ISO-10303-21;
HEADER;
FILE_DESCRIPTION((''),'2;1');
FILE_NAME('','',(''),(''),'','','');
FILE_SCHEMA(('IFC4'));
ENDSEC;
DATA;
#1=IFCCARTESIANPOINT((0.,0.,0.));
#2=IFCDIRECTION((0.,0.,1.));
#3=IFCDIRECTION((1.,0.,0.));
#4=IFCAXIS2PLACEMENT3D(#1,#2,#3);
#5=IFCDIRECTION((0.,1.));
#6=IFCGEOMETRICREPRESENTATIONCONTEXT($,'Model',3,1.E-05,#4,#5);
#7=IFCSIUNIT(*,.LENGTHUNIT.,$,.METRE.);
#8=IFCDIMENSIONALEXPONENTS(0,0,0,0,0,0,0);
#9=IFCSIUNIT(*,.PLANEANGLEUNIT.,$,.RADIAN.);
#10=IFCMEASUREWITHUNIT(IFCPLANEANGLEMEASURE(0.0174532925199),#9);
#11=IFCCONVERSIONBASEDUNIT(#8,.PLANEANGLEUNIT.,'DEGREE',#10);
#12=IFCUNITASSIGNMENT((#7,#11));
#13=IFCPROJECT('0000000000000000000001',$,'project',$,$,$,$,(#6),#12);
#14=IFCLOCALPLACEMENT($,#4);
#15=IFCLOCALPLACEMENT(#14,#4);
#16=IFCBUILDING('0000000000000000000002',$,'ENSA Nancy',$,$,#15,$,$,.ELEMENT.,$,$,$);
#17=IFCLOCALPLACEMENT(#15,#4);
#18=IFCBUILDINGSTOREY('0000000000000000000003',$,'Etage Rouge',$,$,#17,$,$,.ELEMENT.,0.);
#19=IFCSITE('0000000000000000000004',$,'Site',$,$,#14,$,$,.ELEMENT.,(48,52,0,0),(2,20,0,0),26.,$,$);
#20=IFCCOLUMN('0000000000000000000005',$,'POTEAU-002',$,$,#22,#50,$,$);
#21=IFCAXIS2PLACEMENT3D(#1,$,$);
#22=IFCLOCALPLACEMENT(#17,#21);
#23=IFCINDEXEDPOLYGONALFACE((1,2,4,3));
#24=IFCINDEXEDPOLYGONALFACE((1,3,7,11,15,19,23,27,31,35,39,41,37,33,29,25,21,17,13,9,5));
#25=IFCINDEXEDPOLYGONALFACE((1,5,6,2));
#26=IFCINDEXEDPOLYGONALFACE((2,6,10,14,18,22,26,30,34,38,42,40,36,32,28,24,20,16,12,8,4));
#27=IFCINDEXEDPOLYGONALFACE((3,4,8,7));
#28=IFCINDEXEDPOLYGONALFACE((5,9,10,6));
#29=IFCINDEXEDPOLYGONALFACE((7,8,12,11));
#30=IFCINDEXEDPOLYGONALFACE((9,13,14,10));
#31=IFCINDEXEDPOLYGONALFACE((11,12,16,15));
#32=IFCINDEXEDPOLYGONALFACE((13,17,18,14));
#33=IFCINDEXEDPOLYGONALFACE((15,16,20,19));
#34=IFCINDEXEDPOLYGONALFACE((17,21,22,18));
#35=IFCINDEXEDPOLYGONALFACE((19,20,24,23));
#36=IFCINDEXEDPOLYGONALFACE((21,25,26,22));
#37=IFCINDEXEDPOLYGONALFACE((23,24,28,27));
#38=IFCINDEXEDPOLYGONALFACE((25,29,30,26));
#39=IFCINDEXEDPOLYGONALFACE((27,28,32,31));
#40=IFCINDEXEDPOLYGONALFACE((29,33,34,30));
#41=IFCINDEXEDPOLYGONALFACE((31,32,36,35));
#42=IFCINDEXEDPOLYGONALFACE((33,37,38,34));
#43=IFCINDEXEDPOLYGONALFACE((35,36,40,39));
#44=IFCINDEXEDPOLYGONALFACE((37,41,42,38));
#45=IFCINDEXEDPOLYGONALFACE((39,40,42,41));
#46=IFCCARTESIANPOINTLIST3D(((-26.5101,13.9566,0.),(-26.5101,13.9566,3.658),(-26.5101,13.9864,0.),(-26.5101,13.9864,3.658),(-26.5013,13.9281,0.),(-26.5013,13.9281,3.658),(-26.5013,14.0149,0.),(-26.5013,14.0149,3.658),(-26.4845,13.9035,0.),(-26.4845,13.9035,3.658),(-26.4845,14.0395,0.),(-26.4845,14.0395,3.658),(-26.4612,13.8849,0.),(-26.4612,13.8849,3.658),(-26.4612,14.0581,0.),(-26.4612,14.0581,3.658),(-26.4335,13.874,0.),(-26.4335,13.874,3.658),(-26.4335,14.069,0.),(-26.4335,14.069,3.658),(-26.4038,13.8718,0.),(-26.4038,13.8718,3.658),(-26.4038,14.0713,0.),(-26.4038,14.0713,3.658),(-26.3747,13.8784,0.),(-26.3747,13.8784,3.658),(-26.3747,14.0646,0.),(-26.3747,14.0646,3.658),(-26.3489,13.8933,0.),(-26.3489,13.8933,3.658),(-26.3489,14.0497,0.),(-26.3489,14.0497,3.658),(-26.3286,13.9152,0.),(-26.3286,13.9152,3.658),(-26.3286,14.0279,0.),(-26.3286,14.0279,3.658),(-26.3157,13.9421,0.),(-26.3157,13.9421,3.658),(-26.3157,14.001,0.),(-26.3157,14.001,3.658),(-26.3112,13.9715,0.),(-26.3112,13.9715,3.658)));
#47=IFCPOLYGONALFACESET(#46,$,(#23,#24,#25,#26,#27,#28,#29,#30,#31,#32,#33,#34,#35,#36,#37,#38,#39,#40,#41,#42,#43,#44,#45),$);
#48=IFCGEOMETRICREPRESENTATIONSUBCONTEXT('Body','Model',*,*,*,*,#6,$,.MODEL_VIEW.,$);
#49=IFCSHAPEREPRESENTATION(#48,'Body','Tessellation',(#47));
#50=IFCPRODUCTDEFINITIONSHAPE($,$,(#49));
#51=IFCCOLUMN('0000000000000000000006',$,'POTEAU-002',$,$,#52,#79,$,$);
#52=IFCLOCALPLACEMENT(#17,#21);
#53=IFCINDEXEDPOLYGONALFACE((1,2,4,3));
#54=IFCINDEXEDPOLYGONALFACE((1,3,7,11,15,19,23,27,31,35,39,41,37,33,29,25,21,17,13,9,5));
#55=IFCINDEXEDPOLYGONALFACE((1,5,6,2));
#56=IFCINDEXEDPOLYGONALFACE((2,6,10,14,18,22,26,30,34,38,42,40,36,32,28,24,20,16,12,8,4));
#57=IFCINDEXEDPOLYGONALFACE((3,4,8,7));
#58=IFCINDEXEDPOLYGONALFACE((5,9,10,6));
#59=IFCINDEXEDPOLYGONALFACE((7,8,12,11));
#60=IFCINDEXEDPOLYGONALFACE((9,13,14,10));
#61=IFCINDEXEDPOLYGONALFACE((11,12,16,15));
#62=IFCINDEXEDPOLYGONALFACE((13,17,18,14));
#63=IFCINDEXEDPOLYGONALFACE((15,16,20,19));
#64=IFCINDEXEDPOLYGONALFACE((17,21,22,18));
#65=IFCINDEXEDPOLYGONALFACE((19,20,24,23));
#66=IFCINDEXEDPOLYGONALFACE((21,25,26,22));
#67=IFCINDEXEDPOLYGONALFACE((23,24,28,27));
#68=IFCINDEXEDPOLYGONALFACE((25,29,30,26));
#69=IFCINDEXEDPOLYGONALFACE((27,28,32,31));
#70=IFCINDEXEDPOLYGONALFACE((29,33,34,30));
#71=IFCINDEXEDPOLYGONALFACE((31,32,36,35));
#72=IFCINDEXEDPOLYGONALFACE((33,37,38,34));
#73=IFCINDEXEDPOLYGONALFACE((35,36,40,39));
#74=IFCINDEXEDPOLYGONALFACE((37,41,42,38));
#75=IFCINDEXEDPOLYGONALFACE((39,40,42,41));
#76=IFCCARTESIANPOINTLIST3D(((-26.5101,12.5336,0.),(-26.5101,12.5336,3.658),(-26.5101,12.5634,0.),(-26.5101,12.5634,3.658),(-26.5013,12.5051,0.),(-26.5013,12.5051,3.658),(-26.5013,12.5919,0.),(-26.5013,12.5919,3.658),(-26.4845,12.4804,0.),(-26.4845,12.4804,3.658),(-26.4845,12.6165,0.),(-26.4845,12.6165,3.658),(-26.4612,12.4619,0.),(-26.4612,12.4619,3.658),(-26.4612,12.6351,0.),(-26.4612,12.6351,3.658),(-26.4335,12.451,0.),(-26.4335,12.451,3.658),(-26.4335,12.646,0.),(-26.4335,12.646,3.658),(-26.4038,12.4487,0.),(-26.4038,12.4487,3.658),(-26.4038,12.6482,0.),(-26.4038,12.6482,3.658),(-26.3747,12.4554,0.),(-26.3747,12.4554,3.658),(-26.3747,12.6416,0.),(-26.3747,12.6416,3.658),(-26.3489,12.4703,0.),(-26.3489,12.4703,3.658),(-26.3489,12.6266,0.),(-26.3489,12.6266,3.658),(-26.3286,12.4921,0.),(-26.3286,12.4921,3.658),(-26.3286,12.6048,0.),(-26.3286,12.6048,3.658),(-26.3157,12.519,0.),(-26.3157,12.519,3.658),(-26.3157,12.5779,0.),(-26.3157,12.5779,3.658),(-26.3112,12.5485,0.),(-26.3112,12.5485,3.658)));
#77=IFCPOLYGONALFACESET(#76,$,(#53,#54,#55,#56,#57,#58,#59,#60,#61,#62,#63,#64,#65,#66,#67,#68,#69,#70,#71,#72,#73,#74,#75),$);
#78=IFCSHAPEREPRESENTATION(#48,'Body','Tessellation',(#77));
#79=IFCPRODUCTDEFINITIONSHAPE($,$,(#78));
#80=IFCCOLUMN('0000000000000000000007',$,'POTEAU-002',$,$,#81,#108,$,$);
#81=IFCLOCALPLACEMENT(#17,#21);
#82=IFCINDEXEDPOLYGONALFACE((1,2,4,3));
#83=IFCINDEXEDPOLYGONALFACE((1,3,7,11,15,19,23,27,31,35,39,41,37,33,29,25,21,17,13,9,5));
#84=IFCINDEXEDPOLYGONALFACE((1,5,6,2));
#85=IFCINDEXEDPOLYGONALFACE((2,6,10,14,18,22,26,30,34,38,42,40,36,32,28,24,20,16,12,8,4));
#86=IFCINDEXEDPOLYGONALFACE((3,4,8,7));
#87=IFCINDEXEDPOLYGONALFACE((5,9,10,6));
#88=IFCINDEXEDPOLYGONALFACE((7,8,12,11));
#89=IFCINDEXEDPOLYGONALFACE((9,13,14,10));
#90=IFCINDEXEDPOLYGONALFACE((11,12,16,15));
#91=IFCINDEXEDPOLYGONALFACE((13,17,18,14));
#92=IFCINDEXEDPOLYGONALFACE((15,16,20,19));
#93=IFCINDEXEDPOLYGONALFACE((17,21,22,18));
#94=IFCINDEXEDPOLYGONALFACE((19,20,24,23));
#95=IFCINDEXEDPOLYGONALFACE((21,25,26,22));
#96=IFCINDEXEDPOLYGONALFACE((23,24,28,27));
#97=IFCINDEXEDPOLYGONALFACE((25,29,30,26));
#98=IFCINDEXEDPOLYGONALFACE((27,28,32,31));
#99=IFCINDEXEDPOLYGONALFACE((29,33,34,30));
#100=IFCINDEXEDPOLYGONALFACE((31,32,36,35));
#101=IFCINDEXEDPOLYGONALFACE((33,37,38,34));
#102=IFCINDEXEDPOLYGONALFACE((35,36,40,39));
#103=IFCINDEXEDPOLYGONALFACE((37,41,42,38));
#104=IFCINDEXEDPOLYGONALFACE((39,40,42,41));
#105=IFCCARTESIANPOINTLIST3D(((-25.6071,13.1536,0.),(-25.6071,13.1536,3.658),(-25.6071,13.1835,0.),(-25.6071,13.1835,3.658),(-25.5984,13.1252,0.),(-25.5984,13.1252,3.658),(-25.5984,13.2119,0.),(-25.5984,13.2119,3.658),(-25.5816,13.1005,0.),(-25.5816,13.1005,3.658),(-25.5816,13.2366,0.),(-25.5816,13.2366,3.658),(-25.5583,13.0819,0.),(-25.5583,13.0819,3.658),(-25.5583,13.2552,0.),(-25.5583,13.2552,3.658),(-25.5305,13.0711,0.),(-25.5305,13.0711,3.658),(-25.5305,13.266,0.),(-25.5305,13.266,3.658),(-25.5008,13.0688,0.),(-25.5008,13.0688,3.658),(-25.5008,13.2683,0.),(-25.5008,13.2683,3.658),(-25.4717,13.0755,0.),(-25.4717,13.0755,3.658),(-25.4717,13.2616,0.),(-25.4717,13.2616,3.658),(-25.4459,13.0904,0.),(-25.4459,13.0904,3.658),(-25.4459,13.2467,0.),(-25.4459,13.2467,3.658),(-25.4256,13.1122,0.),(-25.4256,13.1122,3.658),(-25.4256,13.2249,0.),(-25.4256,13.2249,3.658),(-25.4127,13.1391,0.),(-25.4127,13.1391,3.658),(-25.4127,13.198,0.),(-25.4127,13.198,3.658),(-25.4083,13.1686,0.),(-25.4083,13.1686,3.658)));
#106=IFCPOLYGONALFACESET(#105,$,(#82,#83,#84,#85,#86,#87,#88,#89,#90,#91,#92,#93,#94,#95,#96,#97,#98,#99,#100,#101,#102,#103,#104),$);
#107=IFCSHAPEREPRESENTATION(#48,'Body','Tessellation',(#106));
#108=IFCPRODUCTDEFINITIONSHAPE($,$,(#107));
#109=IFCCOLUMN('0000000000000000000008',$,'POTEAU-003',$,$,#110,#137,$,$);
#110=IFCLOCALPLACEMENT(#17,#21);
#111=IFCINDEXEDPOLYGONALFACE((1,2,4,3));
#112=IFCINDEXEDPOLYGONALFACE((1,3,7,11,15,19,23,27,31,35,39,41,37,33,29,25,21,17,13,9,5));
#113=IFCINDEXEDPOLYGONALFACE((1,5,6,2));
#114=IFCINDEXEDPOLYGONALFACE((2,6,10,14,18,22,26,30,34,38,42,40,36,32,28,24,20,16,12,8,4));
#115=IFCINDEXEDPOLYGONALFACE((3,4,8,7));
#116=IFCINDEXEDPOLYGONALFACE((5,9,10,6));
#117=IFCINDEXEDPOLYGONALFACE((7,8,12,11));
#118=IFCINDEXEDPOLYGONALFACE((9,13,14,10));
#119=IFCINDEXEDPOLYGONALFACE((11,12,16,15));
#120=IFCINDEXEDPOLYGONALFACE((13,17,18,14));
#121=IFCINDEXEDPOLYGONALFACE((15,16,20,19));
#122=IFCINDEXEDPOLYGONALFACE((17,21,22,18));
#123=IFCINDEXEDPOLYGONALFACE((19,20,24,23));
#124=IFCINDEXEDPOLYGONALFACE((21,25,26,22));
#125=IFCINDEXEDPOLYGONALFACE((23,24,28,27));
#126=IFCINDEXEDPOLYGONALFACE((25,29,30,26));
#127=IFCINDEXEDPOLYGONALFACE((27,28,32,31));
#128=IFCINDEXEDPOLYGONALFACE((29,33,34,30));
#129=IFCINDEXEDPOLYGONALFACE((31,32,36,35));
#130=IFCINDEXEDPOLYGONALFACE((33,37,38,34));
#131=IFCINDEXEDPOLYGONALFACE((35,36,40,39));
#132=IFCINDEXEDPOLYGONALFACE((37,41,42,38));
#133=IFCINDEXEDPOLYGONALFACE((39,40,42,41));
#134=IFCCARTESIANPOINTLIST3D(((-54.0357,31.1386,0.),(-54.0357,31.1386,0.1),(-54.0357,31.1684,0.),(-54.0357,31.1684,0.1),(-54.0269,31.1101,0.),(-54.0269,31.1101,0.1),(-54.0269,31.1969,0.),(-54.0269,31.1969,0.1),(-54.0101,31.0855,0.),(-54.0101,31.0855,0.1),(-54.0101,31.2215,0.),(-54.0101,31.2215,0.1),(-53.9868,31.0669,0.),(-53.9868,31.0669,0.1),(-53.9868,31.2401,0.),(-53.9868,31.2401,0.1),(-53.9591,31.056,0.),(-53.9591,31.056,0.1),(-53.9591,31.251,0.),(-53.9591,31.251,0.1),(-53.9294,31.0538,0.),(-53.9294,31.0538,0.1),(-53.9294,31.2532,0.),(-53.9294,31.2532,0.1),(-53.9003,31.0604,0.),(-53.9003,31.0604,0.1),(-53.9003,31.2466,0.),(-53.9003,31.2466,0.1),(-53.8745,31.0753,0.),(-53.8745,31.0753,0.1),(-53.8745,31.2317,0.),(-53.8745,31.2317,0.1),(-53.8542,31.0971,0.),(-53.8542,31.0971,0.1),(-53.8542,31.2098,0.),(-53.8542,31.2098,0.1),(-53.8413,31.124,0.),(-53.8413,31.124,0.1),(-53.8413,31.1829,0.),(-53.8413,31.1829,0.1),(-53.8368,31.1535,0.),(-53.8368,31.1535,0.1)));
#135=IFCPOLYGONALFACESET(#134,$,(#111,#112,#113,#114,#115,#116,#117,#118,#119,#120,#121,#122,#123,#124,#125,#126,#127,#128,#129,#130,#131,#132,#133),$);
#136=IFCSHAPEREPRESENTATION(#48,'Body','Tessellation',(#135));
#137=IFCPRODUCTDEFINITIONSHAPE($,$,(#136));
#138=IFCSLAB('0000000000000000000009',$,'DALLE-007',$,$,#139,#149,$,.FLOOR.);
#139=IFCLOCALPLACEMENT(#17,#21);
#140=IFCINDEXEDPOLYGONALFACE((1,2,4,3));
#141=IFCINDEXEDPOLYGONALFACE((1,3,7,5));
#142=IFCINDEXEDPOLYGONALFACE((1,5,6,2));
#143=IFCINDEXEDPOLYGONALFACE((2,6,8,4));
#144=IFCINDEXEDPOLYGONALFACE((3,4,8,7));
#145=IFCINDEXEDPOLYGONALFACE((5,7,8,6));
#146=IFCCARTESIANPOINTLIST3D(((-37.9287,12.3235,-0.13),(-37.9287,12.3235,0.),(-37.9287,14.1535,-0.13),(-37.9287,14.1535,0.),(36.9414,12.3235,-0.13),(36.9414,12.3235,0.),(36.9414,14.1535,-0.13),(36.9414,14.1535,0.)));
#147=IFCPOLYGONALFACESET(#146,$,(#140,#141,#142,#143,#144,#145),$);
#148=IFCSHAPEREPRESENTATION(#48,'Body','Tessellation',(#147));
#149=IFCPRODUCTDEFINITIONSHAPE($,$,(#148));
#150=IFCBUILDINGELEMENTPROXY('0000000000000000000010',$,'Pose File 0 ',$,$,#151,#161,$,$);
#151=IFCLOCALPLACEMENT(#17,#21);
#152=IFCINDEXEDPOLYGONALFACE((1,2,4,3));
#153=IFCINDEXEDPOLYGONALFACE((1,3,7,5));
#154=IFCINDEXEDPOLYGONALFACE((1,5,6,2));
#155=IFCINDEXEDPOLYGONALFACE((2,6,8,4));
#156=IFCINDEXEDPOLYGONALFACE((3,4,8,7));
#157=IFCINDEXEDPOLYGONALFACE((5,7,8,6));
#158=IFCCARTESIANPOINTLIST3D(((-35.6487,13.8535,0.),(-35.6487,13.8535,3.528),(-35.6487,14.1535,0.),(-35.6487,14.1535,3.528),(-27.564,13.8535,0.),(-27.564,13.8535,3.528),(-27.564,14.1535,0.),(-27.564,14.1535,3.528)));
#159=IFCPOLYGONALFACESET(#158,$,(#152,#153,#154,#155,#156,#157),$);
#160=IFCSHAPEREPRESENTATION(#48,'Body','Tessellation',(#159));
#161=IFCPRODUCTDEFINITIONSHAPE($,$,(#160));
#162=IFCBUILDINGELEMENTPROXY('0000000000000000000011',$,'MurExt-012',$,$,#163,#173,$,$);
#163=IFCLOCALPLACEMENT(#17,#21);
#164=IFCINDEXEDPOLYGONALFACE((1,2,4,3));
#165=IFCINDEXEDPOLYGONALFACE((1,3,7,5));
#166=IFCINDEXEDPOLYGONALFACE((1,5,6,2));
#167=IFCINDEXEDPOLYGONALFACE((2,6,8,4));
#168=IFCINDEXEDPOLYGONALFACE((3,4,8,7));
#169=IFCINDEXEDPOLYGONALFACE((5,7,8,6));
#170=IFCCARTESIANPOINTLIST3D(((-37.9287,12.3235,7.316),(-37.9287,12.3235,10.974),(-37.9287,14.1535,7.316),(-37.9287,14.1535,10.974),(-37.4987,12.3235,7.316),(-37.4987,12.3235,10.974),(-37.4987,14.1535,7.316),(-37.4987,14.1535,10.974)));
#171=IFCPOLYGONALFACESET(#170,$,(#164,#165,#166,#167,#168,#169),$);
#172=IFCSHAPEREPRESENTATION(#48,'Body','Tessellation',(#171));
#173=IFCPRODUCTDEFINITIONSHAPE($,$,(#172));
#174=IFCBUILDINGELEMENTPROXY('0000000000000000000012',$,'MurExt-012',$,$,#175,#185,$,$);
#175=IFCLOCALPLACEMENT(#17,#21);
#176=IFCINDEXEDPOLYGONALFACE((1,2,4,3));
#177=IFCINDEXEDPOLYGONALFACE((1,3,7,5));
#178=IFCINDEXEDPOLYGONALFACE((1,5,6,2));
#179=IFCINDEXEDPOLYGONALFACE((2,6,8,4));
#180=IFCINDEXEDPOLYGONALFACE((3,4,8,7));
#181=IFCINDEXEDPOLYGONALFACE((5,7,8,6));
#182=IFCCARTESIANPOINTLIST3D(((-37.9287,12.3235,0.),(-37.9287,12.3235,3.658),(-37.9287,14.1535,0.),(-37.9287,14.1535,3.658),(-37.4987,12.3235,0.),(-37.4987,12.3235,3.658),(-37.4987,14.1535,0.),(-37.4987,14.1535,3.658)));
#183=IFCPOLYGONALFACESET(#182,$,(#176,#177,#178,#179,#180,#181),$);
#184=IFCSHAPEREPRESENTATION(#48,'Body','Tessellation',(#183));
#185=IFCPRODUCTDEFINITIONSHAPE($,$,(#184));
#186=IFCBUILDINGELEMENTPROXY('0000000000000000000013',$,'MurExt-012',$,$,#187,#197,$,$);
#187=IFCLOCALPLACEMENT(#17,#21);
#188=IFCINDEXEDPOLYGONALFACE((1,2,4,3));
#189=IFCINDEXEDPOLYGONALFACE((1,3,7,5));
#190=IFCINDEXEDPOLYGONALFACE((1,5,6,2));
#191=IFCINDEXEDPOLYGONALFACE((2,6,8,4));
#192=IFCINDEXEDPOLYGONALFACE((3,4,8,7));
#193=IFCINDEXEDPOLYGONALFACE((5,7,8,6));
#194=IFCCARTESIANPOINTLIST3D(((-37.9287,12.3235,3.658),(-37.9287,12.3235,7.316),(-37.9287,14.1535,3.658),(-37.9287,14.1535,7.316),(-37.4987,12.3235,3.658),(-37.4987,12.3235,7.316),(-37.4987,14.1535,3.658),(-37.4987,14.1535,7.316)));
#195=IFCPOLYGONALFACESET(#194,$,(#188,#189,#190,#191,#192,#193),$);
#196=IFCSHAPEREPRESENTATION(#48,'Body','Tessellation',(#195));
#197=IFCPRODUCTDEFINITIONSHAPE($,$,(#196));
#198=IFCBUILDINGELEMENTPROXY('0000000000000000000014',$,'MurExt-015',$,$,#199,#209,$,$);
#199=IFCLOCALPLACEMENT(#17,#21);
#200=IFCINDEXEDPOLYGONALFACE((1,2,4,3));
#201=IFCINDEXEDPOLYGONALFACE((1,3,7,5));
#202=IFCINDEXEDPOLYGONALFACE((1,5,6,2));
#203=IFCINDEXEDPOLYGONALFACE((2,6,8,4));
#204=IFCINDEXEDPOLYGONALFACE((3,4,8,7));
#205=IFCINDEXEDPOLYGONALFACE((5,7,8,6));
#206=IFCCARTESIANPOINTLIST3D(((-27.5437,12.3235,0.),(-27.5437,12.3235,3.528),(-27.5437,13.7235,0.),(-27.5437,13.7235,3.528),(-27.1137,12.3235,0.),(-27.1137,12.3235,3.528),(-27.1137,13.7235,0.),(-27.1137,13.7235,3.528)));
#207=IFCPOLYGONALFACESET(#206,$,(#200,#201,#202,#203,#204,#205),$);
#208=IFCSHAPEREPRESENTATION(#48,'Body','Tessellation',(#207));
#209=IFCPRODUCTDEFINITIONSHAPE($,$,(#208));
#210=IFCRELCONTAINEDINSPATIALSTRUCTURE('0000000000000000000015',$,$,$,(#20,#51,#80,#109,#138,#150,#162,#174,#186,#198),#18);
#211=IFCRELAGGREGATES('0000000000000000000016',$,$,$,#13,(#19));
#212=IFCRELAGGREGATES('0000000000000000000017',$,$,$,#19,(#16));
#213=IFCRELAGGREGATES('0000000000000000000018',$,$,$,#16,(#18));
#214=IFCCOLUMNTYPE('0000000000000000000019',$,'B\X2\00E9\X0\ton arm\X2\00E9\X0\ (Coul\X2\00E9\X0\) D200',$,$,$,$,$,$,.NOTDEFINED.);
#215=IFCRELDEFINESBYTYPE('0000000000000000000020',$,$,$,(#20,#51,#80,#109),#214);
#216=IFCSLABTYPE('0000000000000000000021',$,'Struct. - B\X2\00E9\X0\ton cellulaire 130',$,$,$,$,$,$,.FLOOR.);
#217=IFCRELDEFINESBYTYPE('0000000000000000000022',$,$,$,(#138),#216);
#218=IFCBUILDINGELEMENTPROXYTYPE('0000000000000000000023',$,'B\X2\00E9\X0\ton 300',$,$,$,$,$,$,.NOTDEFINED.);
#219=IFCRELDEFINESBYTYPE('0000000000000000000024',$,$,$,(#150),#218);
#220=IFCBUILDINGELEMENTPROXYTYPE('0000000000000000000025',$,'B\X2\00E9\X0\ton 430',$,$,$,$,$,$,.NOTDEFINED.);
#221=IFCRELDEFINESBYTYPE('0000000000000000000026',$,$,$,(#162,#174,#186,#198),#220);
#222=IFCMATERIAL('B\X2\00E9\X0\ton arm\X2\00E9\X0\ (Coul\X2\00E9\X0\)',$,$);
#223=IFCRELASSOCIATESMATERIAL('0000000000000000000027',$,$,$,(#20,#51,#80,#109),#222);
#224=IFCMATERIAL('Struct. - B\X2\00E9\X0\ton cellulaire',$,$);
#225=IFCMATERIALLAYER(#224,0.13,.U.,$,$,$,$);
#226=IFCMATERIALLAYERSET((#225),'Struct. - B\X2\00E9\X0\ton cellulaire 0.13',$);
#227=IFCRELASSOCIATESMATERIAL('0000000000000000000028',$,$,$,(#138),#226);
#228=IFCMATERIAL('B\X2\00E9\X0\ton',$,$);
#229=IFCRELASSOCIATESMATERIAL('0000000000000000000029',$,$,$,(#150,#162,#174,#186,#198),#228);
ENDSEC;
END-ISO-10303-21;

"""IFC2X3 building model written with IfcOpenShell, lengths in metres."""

from ifc_helpers import new_model, entity, si_unit, converted_unit, direction, frame, origin_with_axes, origin_2d_with_axis, place, context, subcontext, project, spatial, polyline, circle, outline, extrude, material, layer, layer_set, layer_usage, type_object, element, save


model = new_model("IFC2X3")

# Units and contexts
model_context = context("Model", 3, precision=1e-05, world=origin_with_axes(), true_north=direction((0.0, 1.0)))
body_context = subcontext(model_context, "Body", "Model", "MODEL_VIEW")
ifc_project = project(units=[si_unit("LENGTHUNIT", "METRE"), converted_unit("PLANEANGLEUNIT", "DEGREE", entity("IfcPlaneAngleMeasure", 0.0174532925199), si_unit("PLANEANGLEUNIT", "RADIAN"), dimensions=[0, 0, 0, 0, 0, 0, 0])], contexts=[model_context])

# Site, building, storey
site_placement = place(None, origin_with_axes())
site = spatial("IfcSite", under=ifc_project, at=site_placement, Name="Site", CompositionType="ELEMENT", RefLatitude=(48, 52, 0, 0), RefLongitude=(2, 20, 0, 0), RefElevation=26.0)
building_placement = place(site_placement, origin_with_axes())
building = spatial("IfcBuilding", under=site, at=building_placement, Name="ENSA Nancy", CompositionType="ELEMENT")
storey_placement = place(building_placement, origin_with_axes())
storey = spatial("IfcBuildingStorey", under=building, at=storey_placement, Name="Etage Rouge", CompositionType="ELEMENT", Elevation=0.0)

# Columns
ifc_material_1 = material(Name="Béton armé (Coulé)")
column_type = type_object("IfcColumnType", Name="Béton armé (Coulé) D200", PredefinedType="NOTDEFINED")
for number, where, z_axis, x_axis, name in (
    (1, (-26.4112, 13.9715, 0.0), (0.0, 0.0, 1.0), (1.0, 0.0, 0.0), "POTEAU-002"),
    (2, (-26.4112, 12.5485, 0.0), (0.0, 0.0, 1.0), (1.0, 0.0, 0.0), "POTEAU-002"),
    (3, (-25.5083, 13.1686, 0.0), (0.0, 0.0, 1.0), (1.0, 0.0, 0.0), "POTEAU-002"),
):
    element("IfcColumn", number, at=place(storey_placement, frame(where, z_axis=z_axis, x_axis=x_axis)), inside=storey, type_object=column_type, material=ifc_material_1, Name=name, context=body_context, shape_type="SweptSolid", body=[
        extrude(circle(Radius=0.1, at=origin_2d_with_axis()), origin_with_axes(), (0.0, 0.0, 1.0), 3.658),
    ])
column_placement = place(storey_placement, frame((-53.9368, 31.1535, 0.0), z_axis=(0.0, 0.0, 1.0), x_axis=(1.0, 0.0, 0.0)))
element("IfcColumn", 4, at=column_placement, inside=storey, type_object=column_type, material=ifc_material_1, Name="POTEAU-003", context=body_context, shape_type="SweptSolid", body=[
    extrude(circle(Radius=0.1, at=origin_2d_with_axis()), origin_with_axes(), (0.0, 0.0, 1.0), 0.1),
])

# Slab
ifc_material_2 = material(Name="Struct. - Béton cellulaire")
ifc_layer = layer(ifc_material_2, 0.13, ventilated="UNKNOWN")
ifc_layer_set = layer_set([ifc_layer], Name="Struct. - Béton cellulaire 0.13")
ifc_layer_usage = layer_usage(ifc_layer_set, "AXIS3", "NEGATIVE", 0.13)
slab_type = type_object("IfcSlabType", Name="Struct. - Béton cellulaire 130", PredefinedType="FLOOR")
slab_placement = place(storey_placement, frame((-37.9287, 12.3235, 0.0), z_axis=(0.0, 0.0, 1.0), x_axis=(1.0, 0.0, 0.0)))
element("IfcSlab", 5, at=slab_placement, inside=storey, type_object=slab_type, material=ifc_layer_usage, Name="DALLE-007", PredefinedType="FLOOR", context=body_context, shape_type="SweptSolid", body=[
    extrude(outline(polyline([(0.0, 0.0), (74.8701, 0.0), (74.8701, 1.83), (0.0, 1.83), (0.0, 0.0)])), frame((0.0, 0.0, -0.13), z_axis=(0.0, 0.0, 1.0), x_axis=(1.0, 0.0, 0.0)), (0.0, 0.0, 1.0), 0.13),
])

# Building element proxies
ifc_material_3 = material(Name="Béton")
building_element_proxy_type_1 = type_object("IfcBuildingElementProxyType", Name="Béton 300", PredefinedType="NOTDEFINED")
proxy_1_placement = place(storey_placement, frame((-27.564, 13.8535, 0.0), z_axis=(0.0, 0.0, 1.0), x_axis=(-1.0, 0.0, 0.0)))
element("IfcBuildingElementProxy", 6, at=proxy_1_placement, inside=storey, type_object=building_element_proxy_type_1, material=ifc_material_3, Name="Pose File 0 ", context=body_context, shape_type="SweptSolid", body=[
    extrude(outline(polyline([(0.0, -0.3), (8.0848, -0.3), (8.0848, 0.0), (0.0, 0.0), (0.0, -0.3)])), origin_with_axes(), (0.0, 0.0, 1.0), 3.528),
])
building_element_proxy_type_2 = type_object("IfcBuildingElementProxyType", Name="Béton 430", PredefinedType="NOTDEFINED")
for number, where, z_axis, x_axis, name in (
    (7, (-37.9287, 14.1535, 7.316), (0.0, 0.0, 1.0), (0.0, -1.0, 0.0), "MurExt-012"),
    (8, (-37.9287, 14.1535, 0.0), (0.0, 0.0, 1.0), (0.0, -1.0, 0.0), "MurExt-012"),
    (9, (-37.9287, 14.1535, 3.658), (0.0, 0.0, 1.0), (0.0, -1.0, 0.0), "MurExt-012"),
):
    element("IfcBuildingElementProxy", number, at=place(storey_placement, frame(where, z_axis=z_axis, x_axis=x_axis)), inside=storey, type_object=building_element_proxy_type_2, material=ifc_material_3, Name=name, context=body_context, shape_type="SweptSolid", body=[
        extrude(outline(polyline([(0.0, 0.0), (1.83, 0.0), (1.83, 0.43), (0.0, 0.43), (0.0, 0.0)])), origin_with_axes(), (0.0, 0.0, 1.0), 3.658),
    ])
proxy_2_placement = place(storey_placement, frame((-27.5437, 13.7235, 0.0), z_axis=(0.0, 0.0, 1.0), x_axis=(0.0, -1.0, 0.0)))
element("IfcBuildingElementProxy", 10, at=proxy_2_placement, inside=storey, type_object=building_element_proxy_type_2, material=ifc_material_3, Name="MurExt-015", context=body_context, shape_type="SweptSolid", body=[
    extrude(outline(polyline([(0.0, 0.0), (1.4, 0.0), (1.4, 0.43), (0.0, 0.43), (0.0, 0.0)])), origin_with_axes(), (0.0, 0.0, 1.0), 3.528),
])

save(model, "model.ifc")
